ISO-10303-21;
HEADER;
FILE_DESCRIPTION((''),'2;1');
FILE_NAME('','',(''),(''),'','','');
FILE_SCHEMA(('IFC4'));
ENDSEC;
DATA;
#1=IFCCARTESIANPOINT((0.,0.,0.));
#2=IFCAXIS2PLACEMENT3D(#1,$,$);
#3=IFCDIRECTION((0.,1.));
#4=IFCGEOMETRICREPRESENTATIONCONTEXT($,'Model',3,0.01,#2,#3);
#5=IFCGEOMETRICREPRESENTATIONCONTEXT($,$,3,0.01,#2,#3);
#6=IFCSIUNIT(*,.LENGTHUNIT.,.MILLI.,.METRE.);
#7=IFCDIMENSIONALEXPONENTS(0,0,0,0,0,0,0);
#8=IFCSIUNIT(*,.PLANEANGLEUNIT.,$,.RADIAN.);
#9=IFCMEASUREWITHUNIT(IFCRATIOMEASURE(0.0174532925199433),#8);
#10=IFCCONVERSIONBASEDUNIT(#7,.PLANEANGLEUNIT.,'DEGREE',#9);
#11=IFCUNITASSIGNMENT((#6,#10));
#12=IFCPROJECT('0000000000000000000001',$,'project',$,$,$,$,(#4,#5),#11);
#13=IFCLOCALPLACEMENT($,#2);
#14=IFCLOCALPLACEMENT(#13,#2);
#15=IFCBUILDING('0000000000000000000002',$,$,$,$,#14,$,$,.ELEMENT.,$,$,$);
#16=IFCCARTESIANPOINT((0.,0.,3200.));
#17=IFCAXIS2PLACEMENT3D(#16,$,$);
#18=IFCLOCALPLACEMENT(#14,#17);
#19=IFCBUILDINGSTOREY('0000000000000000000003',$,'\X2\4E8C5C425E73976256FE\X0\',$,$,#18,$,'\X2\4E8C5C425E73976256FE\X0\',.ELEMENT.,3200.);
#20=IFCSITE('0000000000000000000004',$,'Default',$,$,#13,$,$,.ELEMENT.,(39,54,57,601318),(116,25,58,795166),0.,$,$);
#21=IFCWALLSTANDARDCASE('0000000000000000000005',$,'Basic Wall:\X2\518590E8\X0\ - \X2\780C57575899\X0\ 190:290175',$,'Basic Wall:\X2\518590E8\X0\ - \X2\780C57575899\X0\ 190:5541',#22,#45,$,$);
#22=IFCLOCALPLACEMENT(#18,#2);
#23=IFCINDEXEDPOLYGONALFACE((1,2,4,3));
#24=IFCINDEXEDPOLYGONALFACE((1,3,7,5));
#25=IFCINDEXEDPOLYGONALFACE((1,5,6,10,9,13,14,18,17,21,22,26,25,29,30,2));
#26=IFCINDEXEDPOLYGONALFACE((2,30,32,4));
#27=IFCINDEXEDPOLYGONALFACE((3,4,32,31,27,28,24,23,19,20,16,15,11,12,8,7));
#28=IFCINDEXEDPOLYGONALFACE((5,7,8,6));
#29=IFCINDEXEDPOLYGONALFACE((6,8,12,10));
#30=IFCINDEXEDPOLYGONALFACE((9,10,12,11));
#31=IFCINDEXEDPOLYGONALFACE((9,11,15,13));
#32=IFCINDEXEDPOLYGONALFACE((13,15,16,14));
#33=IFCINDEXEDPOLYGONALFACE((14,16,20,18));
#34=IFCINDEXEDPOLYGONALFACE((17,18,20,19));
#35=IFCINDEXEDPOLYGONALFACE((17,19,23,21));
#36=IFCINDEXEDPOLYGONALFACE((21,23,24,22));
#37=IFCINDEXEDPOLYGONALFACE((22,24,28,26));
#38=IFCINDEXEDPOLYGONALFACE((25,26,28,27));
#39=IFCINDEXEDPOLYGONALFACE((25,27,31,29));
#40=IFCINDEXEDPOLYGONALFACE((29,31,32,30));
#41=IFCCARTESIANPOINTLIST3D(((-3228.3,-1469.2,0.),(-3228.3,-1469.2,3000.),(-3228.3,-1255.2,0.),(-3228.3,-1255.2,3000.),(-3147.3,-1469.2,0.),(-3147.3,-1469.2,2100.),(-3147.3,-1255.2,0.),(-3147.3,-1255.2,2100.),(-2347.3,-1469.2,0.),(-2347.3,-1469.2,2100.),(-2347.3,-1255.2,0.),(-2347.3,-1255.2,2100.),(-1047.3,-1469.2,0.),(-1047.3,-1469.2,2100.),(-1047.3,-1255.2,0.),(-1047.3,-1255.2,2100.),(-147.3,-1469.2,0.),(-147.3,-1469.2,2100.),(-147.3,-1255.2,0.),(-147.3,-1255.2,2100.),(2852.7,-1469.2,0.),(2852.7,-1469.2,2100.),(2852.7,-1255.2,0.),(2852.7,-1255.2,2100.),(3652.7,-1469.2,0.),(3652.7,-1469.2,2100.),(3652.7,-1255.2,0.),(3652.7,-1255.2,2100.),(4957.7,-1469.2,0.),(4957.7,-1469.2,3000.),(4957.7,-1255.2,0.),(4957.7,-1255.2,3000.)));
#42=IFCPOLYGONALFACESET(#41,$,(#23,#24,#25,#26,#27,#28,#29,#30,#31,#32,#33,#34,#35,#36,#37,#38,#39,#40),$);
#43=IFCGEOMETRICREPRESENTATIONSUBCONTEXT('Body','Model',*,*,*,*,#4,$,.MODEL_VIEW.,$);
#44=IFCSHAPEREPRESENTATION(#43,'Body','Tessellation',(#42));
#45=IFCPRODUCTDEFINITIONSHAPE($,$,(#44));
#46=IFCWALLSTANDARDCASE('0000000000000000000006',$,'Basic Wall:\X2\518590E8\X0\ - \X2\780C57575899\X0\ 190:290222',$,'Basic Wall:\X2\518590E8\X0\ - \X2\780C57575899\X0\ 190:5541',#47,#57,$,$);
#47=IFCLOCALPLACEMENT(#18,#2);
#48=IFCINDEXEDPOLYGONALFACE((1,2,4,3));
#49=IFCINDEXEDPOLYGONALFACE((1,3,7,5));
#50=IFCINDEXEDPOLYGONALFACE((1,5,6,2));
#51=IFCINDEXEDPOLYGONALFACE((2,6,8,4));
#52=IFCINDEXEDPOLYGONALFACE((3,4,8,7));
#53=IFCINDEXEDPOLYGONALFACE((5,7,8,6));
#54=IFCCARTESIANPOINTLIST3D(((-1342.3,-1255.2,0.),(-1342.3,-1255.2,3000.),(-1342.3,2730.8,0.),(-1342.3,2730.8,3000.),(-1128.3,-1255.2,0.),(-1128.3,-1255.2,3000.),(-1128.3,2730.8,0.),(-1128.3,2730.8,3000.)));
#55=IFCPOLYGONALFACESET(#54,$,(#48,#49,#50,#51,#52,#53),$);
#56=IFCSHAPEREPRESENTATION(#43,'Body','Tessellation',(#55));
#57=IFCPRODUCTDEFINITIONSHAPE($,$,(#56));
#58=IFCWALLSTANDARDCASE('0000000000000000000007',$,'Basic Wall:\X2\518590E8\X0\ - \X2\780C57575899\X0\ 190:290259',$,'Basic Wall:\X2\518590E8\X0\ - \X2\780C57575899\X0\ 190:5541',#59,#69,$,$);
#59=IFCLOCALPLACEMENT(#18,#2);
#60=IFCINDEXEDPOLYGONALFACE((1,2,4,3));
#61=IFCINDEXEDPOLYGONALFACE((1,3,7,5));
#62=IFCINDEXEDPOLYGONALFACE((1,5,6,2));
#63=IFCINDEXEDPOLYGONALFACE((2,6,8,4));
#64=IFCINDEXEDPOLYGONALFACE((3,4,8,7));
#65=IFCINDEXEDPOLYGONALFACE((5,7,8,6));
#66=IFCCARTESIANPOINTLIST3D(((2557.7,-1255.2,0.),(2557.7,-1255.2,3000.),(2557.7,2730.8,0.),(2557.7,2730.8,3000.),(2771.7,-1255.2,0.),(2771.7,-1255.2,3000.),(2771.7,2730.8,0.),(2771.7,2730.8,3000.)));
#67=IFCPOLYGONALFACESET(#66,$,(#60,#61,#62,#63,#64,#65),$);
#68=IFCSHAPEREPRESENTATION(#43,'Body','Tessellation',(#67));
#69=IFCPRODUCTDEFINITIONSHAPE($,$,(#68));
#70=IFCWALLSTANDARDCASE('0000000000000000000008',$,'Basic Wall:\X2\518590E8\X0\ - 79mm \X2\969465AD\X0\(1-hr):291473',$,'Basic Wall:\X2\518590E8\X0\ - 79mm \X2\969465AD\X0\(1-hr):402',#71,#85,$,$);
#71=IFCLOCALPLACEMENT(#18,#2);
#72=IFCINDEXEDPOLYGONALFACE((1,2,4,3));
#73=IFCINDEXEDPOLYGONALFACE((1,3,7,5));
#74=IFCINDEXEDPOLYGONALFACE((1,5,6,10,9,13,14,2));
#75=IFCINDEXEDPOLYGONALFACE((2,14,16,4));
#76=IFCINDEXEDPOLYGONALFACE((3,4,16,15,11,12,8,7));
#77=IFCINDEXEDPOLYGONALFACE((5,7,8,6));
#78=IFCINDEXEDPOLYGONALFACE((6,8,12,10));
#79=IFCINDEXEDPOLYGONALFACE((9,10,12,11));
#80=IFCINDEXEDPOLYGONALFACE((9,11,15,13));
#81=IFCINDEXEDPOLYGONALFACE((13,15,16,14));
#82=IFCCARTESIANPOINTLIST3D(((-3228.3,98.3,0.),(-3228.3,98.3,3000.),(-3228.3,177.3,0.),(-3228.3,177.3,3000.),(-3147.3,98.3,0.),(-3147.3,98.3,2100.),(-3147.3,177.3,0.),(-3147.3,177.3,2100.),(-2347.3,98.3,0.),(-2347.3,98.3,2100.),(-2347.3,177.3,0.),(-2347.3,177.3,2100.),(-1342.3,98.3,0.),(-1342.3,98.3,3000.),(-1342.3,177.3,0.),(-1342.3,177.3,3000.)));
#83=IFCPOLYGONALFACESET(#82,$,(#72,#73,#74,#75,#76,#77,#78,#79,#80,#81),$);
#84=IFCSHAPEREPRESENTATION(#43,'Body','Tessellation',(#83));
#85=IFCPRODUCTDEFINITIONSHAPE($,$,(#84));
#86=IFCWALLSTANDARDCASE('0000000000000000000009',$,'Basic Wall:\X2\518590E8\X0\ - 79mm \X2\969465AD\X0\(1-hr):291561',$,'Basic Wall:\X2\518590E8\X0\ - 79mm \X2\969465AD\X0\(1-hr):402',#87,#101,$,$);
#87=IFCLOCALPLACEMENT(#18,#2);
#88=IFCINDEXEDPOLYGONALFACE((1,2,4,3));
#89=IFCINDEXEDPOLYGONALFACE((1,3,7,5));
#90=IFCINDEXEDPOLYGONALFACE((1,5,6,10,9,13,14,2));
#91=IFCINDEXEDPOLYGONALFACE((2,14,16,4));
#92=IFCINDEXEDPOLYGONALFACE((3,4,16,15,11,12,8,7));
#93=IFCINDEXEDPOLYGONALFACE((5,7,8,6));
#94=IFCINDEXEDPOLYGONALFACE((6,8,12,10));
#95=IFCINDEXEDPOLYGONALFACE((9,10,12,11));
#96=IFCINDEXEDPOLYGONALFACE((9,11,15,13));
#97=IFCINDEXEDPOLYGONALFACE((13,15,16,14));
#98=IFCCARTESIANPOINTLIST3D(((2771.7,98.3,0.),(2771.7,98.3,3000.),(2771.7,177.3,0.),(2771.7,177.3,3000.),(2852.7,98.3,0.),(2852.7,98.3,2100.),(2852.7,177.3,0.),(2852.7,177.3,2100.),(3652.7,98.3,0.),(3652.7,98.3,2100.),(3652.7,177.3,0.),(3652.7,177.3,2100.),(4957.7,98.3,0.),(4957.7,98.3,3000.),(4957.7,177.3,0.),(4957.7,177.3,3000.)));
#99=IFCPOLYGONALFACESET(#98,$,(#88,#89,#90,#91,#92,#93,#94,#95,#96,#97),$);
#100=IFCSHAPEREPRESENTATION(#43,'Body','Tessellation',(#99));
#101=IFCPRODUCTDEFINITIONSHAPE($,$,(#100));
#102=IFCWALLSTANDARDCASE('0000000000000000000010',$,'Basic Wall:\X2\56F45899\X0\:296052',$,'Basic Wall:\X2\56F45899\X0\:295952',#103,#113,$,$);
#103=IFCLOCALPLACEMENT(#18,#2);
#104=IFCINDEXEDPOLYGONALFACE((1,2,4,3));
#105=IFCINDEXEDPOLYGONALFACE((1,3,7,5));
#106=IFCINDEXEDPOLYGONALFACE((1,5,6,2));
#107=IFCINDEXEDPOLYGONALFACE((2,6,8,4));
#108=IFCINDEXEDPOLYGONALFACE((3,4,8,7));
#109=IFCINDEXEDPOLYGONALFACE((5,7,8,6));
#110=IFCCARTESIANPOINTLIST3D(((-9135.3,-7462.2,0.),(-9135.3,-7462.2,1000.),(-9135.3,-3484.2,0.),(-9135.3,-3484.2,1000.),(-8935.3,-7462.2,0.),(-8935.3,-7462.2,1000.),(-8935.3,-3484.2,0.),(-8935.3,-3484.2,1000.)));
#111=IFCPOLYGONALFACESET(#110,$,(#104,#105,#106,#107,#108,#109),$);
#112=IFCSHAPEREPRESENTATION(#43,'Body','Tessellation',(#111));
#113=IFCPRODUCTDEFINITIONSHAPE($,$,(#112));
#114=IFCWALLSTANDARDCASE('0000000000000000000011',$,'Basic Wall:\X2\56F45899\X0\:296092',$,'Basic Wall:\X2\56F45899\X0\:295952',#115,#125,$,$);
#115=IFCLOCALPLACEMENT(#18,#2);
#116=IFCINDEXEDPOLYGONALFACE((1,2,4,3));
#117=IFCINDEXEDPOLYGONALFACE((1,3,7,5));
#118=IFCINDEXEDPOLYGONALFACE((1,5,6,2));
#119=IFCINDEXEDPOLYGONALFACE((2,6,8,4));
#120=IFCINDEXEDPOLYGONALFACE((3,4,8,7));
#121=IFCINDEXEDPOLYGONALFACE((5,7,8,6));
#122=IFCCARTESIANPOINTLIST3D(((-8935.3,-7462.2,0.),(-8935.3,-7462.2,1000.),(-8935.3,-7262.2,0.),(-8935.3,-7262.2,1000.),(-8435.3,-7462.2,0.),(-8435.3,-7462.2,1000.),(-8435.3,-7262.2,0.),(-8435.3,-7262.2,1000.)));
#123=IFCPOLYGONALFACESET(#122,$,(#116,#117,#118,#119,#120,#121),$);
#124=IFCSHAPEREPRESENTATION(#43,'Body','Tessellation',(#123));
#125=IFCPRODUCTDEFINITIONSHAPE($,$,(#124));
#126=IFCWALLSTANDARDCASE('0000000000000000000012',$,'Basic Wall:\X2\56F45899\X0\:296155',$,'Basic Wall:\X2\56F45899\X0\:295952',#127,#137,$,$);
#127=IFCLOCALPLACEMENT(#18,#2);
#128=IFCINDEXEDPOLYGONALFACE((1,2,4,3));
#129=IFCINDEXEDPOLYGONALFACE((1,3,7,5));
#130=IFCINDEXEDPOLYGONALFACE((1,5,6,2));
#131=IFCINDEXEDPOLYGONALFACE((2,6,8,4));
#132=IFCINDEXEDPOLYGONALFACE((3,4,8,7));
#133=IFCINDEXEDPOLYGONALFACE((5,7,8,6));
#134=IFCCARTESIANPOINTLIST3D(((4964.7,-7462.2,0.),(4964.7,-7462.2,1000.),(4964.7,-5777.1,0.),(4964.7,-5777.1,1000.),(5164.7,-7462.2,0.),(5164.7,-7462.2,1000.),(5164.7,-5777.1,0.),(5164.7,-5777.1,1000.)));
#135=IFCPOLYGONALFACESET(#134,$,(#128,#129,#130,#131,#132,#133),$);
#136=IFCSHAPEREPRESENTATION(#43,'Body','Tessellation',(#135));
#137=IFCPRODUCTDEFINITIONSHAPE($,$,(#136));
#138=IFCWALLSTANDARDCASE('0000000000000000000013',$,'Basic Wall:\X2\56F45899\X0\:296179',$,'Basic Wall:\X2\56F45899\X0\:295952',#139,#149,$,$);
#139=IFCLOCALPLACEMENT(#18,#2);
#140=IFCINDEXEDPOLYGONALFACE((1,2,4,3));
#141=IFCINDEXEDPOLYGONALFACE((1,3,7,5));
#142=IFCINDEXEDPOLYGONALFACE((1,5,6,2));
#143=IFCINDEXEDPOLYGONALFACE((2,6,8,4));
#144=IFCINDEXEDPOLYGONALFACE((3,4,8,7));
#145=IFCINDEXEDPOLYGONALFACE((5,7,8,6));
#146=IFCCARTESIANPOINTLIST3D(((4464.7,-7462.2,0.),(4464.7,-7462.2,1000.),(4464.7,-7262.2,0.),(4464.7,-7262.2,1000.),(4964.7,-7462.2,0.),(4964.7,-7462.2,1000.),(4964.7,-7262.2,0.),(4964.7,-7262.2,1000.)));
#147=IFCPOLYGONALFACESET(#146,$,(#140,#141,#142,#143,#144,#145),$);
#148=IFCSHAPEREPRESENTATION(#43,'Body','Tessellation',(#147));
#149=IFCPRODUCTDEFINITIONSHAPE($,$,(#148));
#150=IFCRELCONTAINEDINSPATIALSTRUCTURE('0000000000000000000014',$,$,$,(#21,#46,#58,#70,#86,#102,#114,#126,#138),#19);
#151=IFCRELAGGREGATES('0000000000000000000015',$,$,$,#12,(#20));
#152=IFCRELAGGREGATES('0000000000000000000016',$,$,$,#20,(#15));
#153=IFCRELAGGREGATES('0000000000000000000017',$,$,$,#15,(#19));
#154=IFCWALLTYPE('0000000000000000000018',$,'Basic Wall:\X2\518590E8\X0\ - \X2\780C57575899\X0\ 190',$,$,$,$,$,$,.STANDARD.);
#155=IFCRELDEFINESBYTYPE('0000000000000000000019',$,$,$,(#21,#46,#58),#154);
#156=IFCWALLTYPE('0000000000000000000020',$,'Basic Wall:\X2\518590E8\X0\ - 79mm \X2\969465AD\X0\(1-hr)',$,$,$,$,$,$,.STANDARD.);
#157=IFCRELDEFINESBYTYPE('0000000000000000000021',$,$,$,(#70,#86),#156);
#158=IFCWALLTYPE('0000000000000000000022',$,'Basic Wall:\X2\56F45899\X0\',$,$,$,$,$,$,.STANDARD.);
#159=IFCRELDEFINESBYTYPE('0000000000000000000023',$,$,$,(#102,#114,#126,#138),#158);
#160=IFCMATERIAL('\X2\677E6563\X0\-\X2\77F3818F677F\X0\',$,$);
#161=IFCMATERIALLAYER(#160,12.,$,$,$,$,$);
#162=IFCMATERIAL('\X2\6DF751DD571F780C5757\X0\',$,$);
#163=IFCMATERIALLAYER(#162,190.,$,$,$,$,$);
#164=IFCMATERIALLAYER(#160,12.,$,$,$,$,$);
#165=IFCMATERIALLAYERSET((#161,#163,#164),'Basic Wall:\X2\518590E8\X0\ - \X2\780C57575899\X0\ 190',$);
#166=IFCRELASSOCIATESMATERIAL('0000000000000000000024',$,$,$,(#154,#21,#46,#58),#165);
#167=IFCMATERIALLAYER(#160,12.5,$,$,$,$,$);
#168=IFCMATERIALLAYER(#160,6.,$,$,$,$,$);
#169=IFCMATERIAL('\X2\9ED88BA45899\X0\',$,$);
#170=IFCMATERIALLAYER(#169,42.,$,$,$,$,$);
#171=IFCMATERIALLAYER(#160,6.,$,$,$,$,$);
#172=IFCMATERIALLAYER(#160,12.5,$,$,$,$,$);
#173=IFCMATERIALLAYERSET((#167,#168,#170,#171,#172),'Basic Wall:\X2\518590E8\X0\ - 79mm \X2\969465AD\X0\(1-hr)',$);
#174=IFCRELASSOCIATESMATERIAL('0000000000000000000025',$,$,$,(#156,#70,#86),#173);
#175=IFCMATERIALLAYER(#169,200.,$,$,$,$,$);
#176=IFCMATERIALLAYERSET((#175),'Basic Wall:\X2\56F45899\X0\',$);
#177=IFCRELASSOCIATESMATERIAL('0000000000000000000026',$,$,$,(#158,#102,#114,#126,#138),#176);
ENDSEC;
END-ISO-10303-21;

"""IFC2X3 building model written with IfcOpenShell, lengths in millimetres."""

from ifc_helpers import new_model, entity, si_unit, converted_unit, direction, frame, frame_2d, origin, place, context, subcontext, project, spatial, rectangle, extrude, material, layer, layer_set, layer_usage, type_object, element, save


model = new_model("IFC2X3")

# Units and contexts
model_context = context("Model", 3, precision=0.01, world=origin(), true_north=direction((0.0, 1.0)))
context_of_model = context(None, 3, precision=0.01, world=origin(), true_north=direction((0.0, 1.0)))
body_context = subcontext(model_context, "Body", "Model", "MODEL_VIEW")
ifc_project = project(units=[si_unit("LENGTHUNIT", "METRE", prefix="MILLI"), converted_unit("PLANEANGLEUNIT", "DEGREE", entity("IfcRatioMeasure", 0.0174532925199433), si_unit("PLANEANGLEUNIT", "RADIAN"), dimensions=[0, 0, 0, 0, 0, 0, 0])], contexts=[model_context, context_of_model])

# Site, building, storey
site_placement = place(None, origin())
site = spatial("IfcSite", under=ifc_project, at=site_placement, Name="Default", CompositionType="ELEMENT", RefLatitude=(39, 54, 57, 601318), RefLongitude=(116, 25, 58, 795166), RefElevation=0.0)
building_placement = place(site_placement, origin())
building = spatial("IfcBuilding", under=site, at=building_placement, CompositionType="ELEMENT")
storey_placement = place(building_placement, frame((0.0, 0.0, 3200.0)))
storey = spatial("IfcBuildingStorey", under=building, at=storey_placement, Name="二层平面图", LongName="二层平面图", CompositionType="ELEMENT", Elevation=3200.0)

# Shared definitions
ifc_material_1 = material(Name="松散-石膏板")
ifc_layer_1 = layer(ifc_material_1, 12.0)
ifc_material_2 = material(Name="混凝土砌块")
ifc_layer_2 = layer(ifc_material_2, 190.0)
ifc_layer_3 = layer(ifc_material_1, 12.0)
ifc_layer_set_1 = layer_set([ifc_layer_1, ifc_layer_2, ifc_layer_3], Name="Basic Wall:内部 - 砌块墙 190")
wall_type_1 = type_object("IfcWallType", Name="Basic Wall:内部 - 砌块墙 190", PredefinedType="STANDARD", material=ifc_layer_set_1)

# Wall, openings
ifc_layer_usage_1 = layer_usage(ifc_layer_set_1, "AXIS2", "NEGATIVE", 107.0)
wall_1_placement = place(storey_placement, frame((-3228.3, -1362.2, 0.0)))
wall_1 = element("IfcWallStandardCase", 1, at=wall_1_placement, inside=storey, type_object=wall_type_1, material=ifc_layer_usage_1, Name="Basic Wall:内部 - 砌块墙 190:290175", ObjectType="Basic Wall:内部 - 砌块墙 190:5541", context=body_context, shape_type="SweptSolid", body=[
    extrude(rectangle(XDim=8186.0, YDim=214.0, at=frame_2d((4093.0, 0.0), x_axis=(-1.0, 0.0))), origin(), (0.0, 0.0, 1.0), 3000.0),
])
opening_1_placement = place(wall_1_placement, frame((2181.0, -107.0, 0.0)))
element("IfcOpeningElement", 2, at=opening_1_placement, cuts=wall_1, ObjectType="Opening", context=body_context, shape_type="SweptSolid", body=[
    extrude(rectangle(XDim=900.0, YDim=2100.0, at=frame_2d((1050.0, 450.0), x_axis=(0.0, 1.0))), frame((0.0, 0.0, 0.0), z_axis=(0.0, 1.0, 0.0), x_axis=(0.0, 0.0, 1.0)), (0.0, 0.0, 1.0), 214.0),
])
opening_2_placement = place(wall_1_placement, frame((81.0, -107.0, 0.0)))
element("IfcOpeningElement", 3, at=opening_2_placement, cuts=wall_1, ObjectType="Opening", context=body_context, shape_type="SweptSolid", body=[
    extrude(rectangle(XDim=800.0, YDim=2100.0, at=frame_2d((1050.0, 400.0), x_axis=(0.0, 1.0))), frame((0.0, 0.0, 0.0), z_axis=(0.0, 1.0, 0.0), x_axis=(0.0, 0.0, 1.0)), (0.0, 0.0, 1.0), 214.0),
])
opening_3_placement = place(wall_1_placement, frame((6081.0, -107.0, 0.0)))
element("IfcOpeningElement", 4, at=opening_3_placement, cuts=wall_1, ObjectType="Opening", context=body_context, shape_type="SweptSolid", body=[
    extrude(rectangle(XDim=800.0, YDim=2100.0, at=frame_2d((1050.0, 400.0), x_axis=(0.0, 1.0))), frame((0.0, 0.0, 0.0), z_axis=(0.0, 1.0, 0.0), x_axis=(0.0, 0.0, 1.0)), (0.0, 0.0, 1.0), 214.0),
])

# Walls
ifc_layer_usage_2 = layer_usage(ifc_layer_set_1, "AXIS2", "NEGATIVE", 107.0)
wall_2_placement = place(storey_placement, frame((-1235.3, -1255.2, 0.0), z_axis=(0.0, 0.0, 1.0), x_axis=(0.0, 1.0, 0.0)))
element("IfcWallStandardCase", 5, at=wall_2_placement, inside=storey, type_object=wall_type_1, material=ifc_layer_usage_2, Name="Basic Wall:内部 - 砌块墙 190:290222", ObjectType="Basic Wall:内部 - 砌块墙 190:5541", context=body_context, shape_type="SweptSolid", body=[
    extrude(rectangle(XDim=3986.0, YDim=214.0, at=frame_2d((1993.0, 0.0), x_axis=(-1.0, 0.0))), origin(), (0.0, 0.0, 1.0), 3000.0),
])
ifc_layer_usage_3 = layer_usage(ifc_layer_set_1, "AXIS2", "NEGATIVE", 107.0)
wall_3_placement = place(storey_placement, frame((2664.7, -1255.2, 0.0), z_axis=(0.0, 0.0, 1.0), x_axis=(0.0, 1.0, 0.0)))
element("IfcWallStandardCase", 6, at=wall_3_placement, inside=storey, type_object=wall_type_1, material=ifc_layer_usage_3, Name="Basic Wall:内部 - 砌块墙 190:290259", ObjectType="Basic Wall:内部 - 砌块墙 190:5541", context=body_context, shape_type="SweptSolid", body=[
    extrude(rectangle(XDim=3986.0, YDim=214.0, at=frame_2d((1993.0, 0.0), x_axis=(-1.0, 0.0))), origin(), (0.0, 0.0, 1.0), 3000.0),
])

# Walls, openings
ifc_layer_4 = layer(ifc_material_1, 12.5)
ifc_layer_5 = layer(ifc_material_1, 6.0)
ifc_material_3 = material(Name="默认墙")
ifc_layer_6 = layer(ifc_material_3, 42.0)
ifc_layer_7 = layer(ifc_material_1, 6.0)
ifc_layer_8 = layer(ifc_material_1, 12.5)
ifc_layer_set_2 = layer_set([ifc_layer_4, ifc_layer_5, ifc_layer_6, ifc_layer_7, ifc_layer_8], Name="Basic Wall:内部 - 79mm 隔断(1-hr)")
ifc_layer_usage_4 = layer_usage(ifc_layer_set_2, "AXIS2", "NEGATIVE", 39.5)
wall_type_2 = type_object("IfcWallType", Name="Basic Wall:内部 - 79mm 隔断(1-hr)", PredefinedType="STANDARD", material=ifc_layer_set_2)
wall_4_placement = place(storey_placement, frame((-3228.3, 137.8, 0.0)))
wall_4 = element("IfcWallStandardCase", 7, at=wall_4_placement, inside=storey, type_object=wall_type_2, material=ifc_layer_usage_4, Name="Basic Wall:内部 - 79mm 隔断(1-hr):291473", ObjectType="Basic Wall:内部 - 79mm 隔断(1-hr):402", context=body_context, shape_type="SweptSolid", body=[
    extrude(rectangle(XDim=1886.0, YDim=79.0, at=frame_2d((943.0, 0.0), x_axis=(-1.0, 0.0))), origin(), (0.0, 0.0, 1.0), 3000.0),
])
opening_4_placement = place(wall_4_placement, frame((81.0, -39.5, 0.0)))
element("IfcOpeningElement", 8, at=opening_4_placement, cuts=wall_4, ObjectType="Opening", context=body_context, shape_type="SweptSolid", body=[
    extrude(rectangle(XDim=800.0, YDim=2100.0, at=frame_2d((1050.0, 400.0), x_axis=(0.0, 1.0))), frame((0.0, 0.0, 0.0), z_axis=(0.0, 1.0, 0.0), x_axis=(0.0, 0.0, 1.0)), (0.0, 0.0, 1.0), 79.0),
])
ifc_layer_usage_5 = layer_usage(ifc_layer_set_2, "AXIS2", "NEGATIVE", 39.5)
wall_5_placement = place(storey_placement, frame((2771.7, 137.8, 0.0)))
wall_5 = element("IfcWallStandardCase", 9, at=wall_5_placement, inside=storey, type_object=wall_type_2, material=ifc_layer_usage_5, Name="Basic Wall:内部 - 79mm 隔断(1-hr):291561", ObjectType="Basic Wall:内部 - 79mm 隔断(1-hr):402", context=body_context, shape_type="SweptSolid", body=[
    extrude(rectangle(XDim=2186.0, YDim=79.0, at=frame_2d((1093.0, 0.0), x_axis=(-1.0, 0.0))), origin(), (0.0, 0.0, 1.0), 3000.0),
])
opening_5_placement = place(wall_5_placement, frame((81.0, -39.5, 0.0)))
element("IfcOpeningElement", 10, at=opening_5_placement, cuts=wall_5, ObjectType="Opening", context=body_context, shape_type="SweptSolid", body=[
    extrude(rectangle(XDim=800.0, YDim=2100.0, at=frame_2d((1050.0, 400.0), x_axis=(0.0, 1.0))), frame((0.0, 0.0, 0.0), z_axis=(0.0, 1.0, 0.0), x_axis=(0.0, 0.0, 1.0)), (0.0, 0.0, 1.0), 79.0),
])

# Walls
ifc_layer_9 = layer(ifc_material_3, 200.0)
ifc_layer_set_3 = layer_set([ifc_layer_9], Name="Basic Wall:围墙")
ifc_layer_usage_6 = layer_usage(ifc_layer_set_3, "AXIS2", "NEGATIVE", 100.0)
wall_type_3 = type_object("IfcWallType", Name="Basic Wall:围墙", PredefinedType="STANDARD", material=ifc_layer_set_3)
wall_6_placement = place(storey_placement, frame((-9035.3, -3484.2, 0.0), z_axis=(0.0, 0.0, 1.0), x_axis=(0.0, -1.0, 0.0)))
element("IfcWallStandardCase", 11, at=wall_6_placement, inside=storey, type_object=wall_type_3, material=ifc_layer_usage_6, Name="Basic Wall:围墙:296052", ObjectType="Basic Wall:围墙:295952", context=body_context, shape_type="SweptSolid", body=[
    extrude(rectangle(XDim=3978.0, YDim=200.0, at=frame_2d((1989.0, 0.0), x_axis=(-1.0, 0.0))), origin(), (0.0, 0.0, 1.0), 1000.0),
])
ifc_layer_usage_7 = layer_usage(ifc_layer_set_3, "AXIS2", "NEGATIVE", 100.0)
wall_7_placement = place(storey_placement, frame((-8935.3, -7362.2, 0.0)))
element("IfcWallStandardCase", 12, at=wall_7_placement, inside=storey, type_object=wall_type_3, material=ifc_layer_usage_7, Name="Basic Wall:围墙:296092", ObjectType="Basic Wall:围墙:295952", context=body_context, shape_type="SweptSolid", body=[
    extrude(rectangle(XDim=500.0, YDim=200.0, at=frame_2d((250.0, 0.0), x_axis=(-1.0, 0.0))), origin(), (0.0, 0.0, 1.0), 1000.0),
])
ifc_layer_usage_8 = layer_usage(ifc_layer_set_3, "AXIS2", "NEGATIVE", 100.0)
wall_8_placement = place(storey_placement, frame((5064.7, -5777.1, 0.0), z_axis=(0.0, 0.0, 1.0), x_axis=(0.0, -1.0, 0.0)))
element("IfcWallStandardCase", 13, at=wall_8_placement, inside=storey, type_object=wall_type_3, material=ifc_layer_usage_8, Name="Basic Wall:围墙:296155", ObjectType="Basic Wall:围墙:295952", context=body_context, shape_type="SweptSolid", body=[
    extrude(rectangle(XDim=1685.1, YDim=200.0, at=frame_2d((842.5, 0.0), x_axis=(-1.0, 0.0))), origin(), (0.0, 0.0, 1.0), 1000.0),
])
ifc_layer_usage_9 = layer_usage(ifc_layer_set_3, "AXIS2", "NEGATIVE", 100.0)
wall_9_placement = place(storey_placement, frame((4964.7, -7362.2, 0.0), z_axis=(0.0, 0.0, 1.0), x_axis=(-1.0, 0.0, 0.0)))
element("IfcWallStandardCase", 14, at=wall_9_placement, inside=storey, type_object=wall_type_3, material=ifc_layer_usage_9, Name="Basic Wall:围墙:296179", ObjectType="Basic Wall:围墙:295952", context=body_context, shape_type="SweptSolid", body=[
    extrude(rectangle(XDim=500.0, YDim=200.0, at=frame_2d((250.0, 0.0), x_axis=(-1.0, 0.0))), origin(), (0.0, 0.0, 1.0), 1000.0),
])

save(model, "model.ifc")
